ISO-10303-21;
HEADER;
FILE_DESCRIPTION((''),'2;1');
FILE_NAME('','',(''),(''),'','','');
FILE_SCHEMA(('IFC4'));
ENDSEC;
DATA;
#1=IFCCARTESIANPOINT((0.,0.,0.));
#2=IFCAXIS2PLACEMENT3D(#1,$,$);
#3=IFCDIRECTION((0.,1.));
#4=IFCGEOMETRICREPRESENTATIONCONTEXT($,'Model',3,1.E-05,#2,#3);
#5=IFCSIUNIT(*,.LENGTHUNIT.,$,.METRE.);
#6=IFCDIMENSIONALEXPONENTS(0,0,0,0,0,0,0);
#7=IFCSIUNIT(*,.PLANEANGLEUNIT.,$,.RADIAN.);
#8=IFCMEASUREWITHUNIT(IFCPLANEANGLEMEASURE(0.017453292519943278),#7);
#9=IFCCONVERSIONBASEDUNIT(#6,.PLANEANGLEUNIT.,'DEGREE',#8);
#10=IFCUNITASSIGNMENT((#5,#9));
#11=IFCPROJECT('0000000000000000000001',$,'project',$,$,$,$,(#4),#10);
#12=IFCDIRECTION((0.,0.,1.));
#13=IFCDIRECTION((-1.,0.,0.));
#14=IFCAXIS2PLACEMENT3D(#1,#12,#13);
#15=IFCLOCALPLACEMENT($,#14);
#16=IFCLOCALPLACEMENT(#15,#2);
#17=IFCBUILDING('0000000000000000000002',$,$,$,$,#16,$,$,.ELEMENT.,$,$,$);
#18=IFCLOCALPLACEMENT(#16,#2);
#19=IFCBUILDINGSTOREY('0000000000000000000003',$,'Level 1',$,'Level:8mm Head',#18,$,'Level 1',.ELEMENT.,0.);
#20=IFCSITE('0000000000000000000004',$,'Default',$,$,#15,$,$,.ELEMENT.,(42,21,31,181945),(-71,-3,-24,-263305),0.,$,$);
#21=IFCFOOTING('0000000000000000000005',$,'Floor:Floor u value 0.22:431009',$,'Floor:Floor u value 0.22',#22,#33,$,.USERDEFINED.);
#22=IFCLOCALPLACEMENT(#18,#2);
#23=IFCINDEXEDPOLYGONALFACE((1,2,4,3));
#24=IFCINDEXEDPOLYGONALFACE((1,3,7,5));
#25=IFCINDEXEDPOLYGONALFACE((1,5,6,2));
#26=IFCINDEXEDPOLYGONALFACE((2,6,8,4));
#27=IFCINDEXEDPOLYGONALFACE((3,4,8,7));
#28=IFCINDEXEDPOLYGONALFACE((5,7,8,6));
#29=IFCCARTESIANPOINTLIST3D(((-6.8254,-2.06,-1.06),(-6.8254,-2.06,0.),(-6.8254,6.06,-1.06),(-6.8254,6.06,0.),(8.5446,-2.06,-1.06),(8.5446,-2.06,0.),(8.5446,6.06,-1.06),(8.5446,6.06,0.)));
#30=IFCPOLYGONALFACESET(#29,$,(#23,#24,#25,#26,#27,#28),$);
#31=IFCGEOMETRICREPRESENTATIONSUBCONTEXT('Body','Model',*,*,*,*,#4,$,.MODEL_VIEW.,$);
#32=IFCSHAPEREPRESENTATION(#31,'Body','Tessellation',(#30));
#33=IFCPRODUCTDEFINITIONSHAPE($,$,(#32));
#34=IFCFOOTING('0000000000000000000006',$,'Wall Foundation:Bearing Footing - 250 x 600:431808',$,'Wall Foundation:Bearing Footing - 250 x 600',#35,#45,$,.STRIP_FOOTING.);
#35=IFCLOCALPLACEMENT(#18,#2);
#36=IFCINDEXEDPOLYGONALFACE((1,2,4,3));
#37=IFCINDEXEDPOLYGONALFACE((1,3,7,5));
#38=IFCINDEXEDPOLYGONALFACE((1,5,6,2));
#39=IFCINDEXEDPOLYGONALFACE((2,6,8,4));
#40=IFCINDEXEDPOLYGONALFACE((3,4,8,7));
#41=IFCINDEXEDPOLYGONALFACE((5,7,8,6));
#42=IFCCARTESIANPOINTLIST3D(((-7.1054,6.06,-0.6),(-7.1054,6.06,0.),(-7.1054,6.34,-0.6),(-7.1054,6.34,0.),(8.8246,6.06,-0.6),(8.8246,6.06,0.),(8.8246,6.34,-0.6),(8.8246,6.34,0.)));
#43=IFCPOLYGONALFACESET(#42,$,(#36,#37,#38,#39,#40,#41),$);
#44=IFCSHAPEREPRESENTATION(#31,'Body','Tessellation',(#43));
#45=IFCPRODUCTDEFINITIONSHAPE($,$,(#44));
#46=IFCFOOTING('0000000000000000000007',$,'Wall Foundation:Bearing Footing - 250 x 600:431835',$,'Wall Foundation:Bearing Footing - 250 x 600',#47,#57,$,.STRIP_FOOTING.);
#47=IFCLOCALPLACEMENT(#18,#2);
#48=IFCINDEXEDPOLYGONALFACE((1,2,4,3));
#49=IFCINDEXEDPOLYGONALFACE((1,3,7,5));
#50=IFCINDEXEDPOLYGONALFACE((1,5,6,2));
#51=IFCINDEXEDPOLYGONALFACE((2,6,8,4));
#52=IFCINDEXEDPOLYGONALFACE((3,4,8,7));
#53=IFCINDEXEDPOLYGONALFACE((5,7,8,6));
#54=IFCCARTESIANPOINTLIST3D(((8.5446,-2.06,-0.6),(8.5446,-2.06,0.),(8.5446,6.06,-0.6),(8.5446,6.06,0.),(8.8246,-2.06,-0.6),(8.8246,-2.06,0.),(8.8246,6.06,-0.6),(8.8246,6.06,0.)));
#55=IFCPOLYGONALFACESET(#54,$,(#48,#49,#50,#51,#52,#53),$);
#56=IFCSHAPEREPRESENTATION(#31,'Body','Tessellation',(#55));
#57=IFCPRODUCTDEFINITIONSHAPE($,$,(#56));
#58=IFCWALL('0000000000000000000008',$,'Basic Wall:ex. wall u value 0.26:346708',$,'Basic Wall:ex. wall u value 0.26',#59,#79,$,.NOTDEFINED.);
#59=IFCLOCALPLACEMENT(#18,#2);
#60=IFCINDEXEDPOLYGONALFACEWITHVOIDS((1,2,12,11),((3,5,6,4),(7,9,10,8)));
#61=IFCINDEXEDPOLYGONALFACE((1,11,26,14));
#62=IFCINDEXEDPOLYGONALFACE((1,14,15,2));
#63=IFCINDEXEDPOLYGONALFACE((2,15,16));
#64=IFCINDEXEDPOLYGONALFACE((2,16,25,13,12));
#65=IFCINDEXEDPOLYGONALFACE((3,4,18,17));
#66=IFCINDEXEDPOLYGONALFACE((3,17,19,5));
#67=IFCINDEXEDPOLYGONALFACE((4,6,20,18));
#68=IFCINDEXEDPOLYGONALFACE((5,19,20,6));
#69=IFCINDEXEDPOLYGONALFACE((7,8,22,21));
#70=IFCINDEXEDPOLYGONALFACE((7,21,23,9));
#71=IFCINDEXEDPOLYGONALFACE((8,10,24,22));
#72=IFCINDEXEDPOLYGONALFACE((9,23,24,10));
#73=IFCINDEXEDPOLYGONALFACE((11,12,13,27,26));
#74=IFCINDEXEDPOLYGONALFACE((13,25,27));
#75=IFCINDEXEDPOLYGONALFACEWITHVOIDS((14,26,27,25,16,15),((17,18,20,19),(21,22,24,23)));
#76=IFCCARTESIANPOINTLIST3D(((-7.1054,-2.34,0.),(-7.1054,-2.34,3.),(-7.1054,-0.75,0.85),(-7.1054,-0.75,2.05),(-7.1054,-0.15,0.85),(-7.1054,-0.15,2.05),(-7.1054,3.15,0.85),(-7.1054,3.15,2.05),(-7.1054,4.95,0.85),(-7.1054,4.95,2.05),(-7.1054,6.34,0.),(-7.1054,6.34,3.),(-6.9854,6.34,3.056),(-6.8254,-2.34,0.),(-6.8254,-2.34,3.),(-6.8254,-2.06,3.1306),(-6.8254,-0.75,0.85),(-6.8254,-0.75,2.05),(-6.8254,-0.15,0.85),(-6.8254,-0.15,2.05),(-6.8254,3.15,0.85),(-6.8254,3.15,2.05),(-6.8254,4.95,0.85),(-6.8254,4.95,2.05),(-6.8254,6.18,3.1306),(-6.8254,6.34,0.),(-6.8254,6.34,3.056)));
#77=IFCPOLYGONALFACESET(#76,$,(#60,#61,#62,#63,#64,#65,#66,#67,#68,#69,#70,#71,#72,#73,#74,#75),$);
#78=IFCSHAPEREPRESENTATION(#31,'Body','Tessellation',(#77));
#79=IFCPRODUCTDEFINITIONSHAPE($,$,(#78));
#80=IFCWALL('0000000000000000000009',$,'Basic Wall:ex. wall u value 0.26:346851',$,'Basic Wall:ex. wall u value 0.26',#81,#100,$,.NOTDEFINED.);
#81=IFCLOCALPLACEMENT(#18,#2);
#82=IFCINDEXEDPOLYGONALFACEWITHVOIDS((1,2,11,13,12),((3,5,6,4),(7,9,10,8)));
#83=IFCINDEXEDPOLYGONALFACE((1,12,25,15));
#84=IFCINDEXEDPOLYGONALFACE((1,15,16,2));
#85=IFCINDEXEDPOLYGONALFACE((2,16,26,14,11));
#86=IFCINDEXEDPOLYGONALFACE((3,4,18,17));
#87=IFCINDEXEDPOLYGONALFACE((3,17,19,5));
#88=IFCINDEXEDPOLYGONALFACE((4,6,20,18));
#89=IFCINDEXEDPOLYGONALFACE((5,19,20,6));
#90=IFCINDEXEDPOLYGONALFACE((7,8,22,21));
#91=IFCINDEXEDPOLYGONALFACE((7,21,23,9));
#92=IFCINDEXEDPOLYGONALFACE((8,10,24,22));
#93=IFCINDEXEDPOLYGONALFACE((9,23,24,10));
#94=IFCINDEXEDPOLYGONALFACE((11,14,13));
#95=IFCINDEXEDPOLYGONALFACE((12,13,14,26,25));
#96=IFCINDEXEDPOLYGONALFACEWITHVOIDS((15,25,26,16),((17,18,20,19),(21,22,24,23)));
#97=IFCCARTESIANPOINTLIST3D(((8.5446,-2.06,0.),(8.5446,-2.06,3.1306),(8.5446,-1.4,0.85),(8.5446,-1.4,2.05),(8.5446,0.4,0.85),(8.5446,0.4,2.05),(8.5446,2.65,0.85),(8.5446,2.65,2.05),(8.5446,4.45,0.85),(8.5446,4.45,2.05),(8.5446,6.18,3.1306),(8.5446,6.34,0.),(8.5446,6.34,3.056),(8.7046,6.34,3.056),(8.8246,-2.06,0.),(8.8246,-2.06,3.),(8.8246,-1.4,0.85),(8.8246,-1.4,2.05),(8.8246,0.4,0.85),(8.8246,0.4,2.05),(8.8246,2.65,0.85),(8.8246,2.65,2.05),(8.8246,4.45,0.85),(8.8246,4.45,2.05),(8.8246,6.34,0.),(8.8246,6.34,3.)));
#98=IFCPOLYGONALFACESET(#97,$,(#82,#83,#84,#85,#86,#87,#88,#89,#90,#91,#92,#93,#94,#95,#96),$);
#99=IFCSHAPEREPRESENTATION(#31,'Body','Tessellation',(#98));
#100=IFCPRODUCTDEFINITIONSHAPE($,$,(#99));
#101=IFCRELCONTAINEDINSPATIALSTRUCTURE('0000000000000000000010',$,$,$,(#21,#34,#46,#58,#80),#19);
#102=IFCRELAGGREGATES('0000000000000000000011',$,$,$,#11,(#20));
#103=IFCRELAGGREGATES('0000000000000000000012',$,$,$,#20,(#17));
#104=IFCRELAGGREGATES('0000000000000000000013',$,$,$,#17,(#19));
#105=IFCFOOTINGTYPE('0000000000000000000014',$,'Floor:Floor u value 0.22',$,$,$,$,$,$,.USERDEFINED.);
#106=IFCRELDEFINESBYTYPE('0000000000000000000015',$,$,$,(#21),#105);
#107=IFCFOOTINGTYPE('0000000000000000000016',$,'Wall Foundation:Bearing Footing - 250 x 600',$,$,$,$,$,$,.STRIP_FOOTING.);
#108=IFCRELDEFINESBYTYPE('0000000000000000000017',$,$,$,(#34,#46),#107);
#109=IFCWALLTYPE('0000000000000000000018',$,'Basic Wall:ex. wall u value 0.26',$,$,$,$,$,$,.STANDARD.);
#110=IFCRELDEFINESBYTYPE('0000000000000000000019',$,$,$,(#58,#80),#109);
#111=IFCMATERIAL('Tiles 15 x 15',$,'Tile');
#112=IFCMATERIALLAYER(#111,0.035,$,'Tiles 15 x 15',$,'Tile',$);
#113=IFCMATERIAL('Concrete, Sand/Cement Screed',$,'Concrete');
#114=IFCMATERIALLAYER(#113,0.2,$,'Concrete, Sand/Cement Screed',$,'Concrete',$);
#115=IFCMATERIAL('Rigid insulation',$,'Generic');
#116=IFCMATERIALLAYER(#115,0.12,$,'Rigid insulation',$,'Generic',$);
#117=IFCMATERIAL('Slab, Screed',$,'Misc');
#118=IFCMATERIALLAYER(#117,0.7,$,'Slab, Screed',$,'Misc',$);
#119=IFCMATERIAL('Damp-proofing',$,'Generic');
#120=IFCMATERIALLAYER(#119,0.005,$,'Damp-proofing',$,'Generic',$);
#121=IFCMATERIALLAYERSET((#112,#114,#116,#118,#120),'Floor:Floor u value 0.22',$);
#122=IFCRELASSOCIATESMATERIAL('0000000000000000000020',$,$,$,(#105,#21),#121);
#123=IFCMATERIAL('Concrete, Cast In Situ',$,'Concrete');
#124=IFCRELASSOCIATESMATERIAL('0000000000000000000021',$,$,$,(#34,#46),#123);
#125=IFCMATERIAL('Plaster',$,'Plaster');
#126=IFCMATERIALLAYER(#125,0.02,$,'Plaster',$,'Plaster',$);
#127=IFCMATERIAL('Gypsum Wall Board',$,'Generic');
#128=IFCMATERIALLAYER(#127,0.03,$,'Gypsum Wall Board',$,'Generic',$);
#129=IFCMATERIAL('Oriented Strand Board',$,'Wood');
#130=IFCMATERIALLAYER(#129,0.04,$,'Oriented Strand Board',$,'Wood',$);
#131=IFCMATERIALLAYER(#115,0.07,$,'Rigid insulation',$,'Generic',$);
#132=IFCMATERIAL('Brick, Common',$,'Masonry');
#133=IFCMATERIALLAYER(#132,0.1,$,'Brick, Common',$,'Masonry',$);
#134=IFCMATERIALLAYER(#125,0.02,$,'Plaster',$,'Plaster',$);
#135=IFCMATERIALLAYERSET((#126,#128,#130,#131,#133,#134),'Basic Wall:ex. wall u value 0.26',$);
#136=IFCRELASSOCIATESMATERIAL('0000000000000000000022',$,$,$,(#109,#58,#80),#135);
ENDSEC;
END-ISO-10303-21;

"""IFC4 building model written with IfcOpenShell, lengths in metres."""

from ifc_helpers import new_model, entity, si_unit, converted_unit, direction, frame, frame_2d, origin, origin_2d_with_axis, place, context, subcontext, project, spatial, polyline, rectangle, extrude, clip, bounded_halfspace, material, layer, layer_set, layer_usage, type_object, element, save


model = new_model("IFC4")

# Units and contexts
model_context = context("Model", 3, precision=1e-05, world=origin(), true_north=direction((0.0, 1.0)))
body_context = subcontext(model_context, "Body", "Model", "MODEL_VIEW")
ifc_project = project(units=[si_unit("LENGTHUNIT", "METRE"), converted_unit("PLANEANGLEUNIT", "DEGREE", entity("IfcPlaneAngleMeasure", 0.017453292519943278), si_unit("PLANEANGLEUNIT", "RADIAN"), dimensions=[0, 0, 0, 0, 0, 0, 0])], contexts=[model_context])

# Site, building, storey
site_placement = place(None, frame((0.0, 0.0, 0.0), z_axis=(0.0, 0.0, 1.0), x_axis=(-1.0, 0.0, 0.0)))
site = spatial("IfcSite", under=ifc_project, at=site_placement, Name="Default", CompositionType="ELEMENT", RefLatitude=(42, 21, 31, 181945), RefLongitude=(-71, -3, -24, -263305), RefElevation=0.0)
building_placement = place(site_placement, origin())
building = spatial("IfcBuilding", under=site, at=building_placement, CompositionType="ELEMENT")
storey_placement = place(building_placement, origin())
storey = spatial("IfcBuildingStorey", under=building, at=storey_placement, Name="Level 1", ObjectType="Level:8mm Head", LongName="Level 1", CompositionType="ELEMENT", Elevation=0.0)

# Footings
ifc_material_1 = material(Name="Tiles 15 x 15", Category="Tile")
ifc_layer_1 = layer(ifc_material_1, 0.035, Name="Tiles 15 x 15", Category="Tile")
ifc_material_2 = material(Name="Concrete, Sand/Cement Screed", Category="Concrete")
ifc_layer_2 = layer(ifc_material_2, 0.2, Name="Concrete, Sand/Cement Screed", Category="Concrete")
ifc_material_3 = material(Name="Rigid insulation", Category="Generic")
ifc_layer_3 = layer(ifc_material_3, 0.12, Name="Rigid insulation", Category="Generic")
ifc_material_4 = material(Name="Slab, Screed", Category="Misc")
ifc_layer_4 = layer(ifc_material_4, 0.7, Name="Slab, Screed", Category="Misc")
ifc_material_5 = material(Name="Damp-proofing", Category="Generic")
ifc_layer_5 = layer(ifc_material_5, 0.005, Name="Damp-proofing", Category="Generic")
ifc_layer_set_1 = layer_set([ifc_layer_1, ifc_layer_2, ifc_layer_3, ifc_layer_4, ifc_layer_5], Name="Floor:Floor u value 0.22")
ifc_layer_usage_1 = layer_usage(ifc_layer_set_1, "AXIS3", "POSITIVE", 0.0)
footing_type_1 = type_object("IfcFootingType", Name="Floor:Floor u value 0.22", PredefinedType="USERDEFINED", material=ifc_layer_set_1)
footing_1_placement = place(storey_placement, origin())
element("IfcFooting", 1, at=footing_1_placement, inside=storey, type_object=footing_type_1, material=ifc_layer_usage_1, Name="Floor:Floor u value 0.22:431009", ObjectType="Floor:Floor u value 0.22", PredefinedType="USERDEFINED", context=body_context, shape_type="SweptSolid", body=[
    extrude(rectangle(XDim=8.12, YDim=15.37, at=origin_2d_with_axis()), frame((0.8596, 2.0, 0.0), z_axis=(0.0, 0.0, -1.0), x_axis=(0.0, 1.0, 0.0)), (0.0, 0.0, 1.0), 1.06),
])
ifc_material_6 = material(Name="Concrete, Cast In Situ", Category="Concrete")
footing_type_2 = type_object("IfcFootingType", Name="Wall Foundation:Bearing Footing - 250 x 600", PredefinedType="STRIP_FOOTING")
footing_2_placement = place(storey_placement, frame((-7.1054, 6.06, -0.6)))
element("IfcFooting", 2, at=footing_2_placement, inside=storey, type_object=footing_type_2, material=ifc_material_6, Name="Wall Foundation:Bearing Footing - 250 x 600:431808", ObjectType="Wall Foundation:Bearing Footing - 250 x 600", PredefinedType="STRIP_FOOTING", context=body_context, shape_type="SweptSolid", body=[
    extrude(rectangle(XDim=15.93, YDim=0.28, at=frame_2d((0.0, -0.0467), x_axis=(1.0, 0.0))), frame((7.965, 0.0933, 0.0), z_axis=(0.0, 0.0, 1.0), x_axis=(-1.0, 0.0, 0.0)), (0.0, 0.0, 1.0), 0.6),
])
footing_3_placement = place(storey_placement, frame((8.5446, -2.06, -0.6)))
element("IfcFooting", 3, at=footing_3_placement, inside=storey, type_object=footing_type_2, material=ifc_material_6, Name="Wall Foundation:Bearing Footing - 250 x 600:431835", ObjectType="Wall Foundation:Bearing Footing - 250 x 600", PredefinedType="STRIP_FOOTING", context=body_context, shape_type="SweptSolid", body=[
    extrude(rectangle(XDim=8.12, YDim=0.28, at=frame_2d((0.0, 0.0), x_axis=(1.0, 0.0))), frame((0.14, 4.06, 0.0), z_axis=(0.0, 0.0, 1.0), x_axis=(0.0, -1.0, 0.0)), (0.0, 0.0, 1.0), 0.6),
])

# Walls, openings
ifc_material_7 = material(Name="Plaster", Category="Plaster")
ifc_layer_6 = layer(ifc_material_7, 0.02, Name="Plaster", Category="Plaster")
ifc_material_8 = material(Name="Gypsum Wall Board", Category="Generic")
ifc_layer_7 = layer(ifc_material_8, 0.03, Name="Gypsum Wall Board", Category="Generic")
ifc_material_9 = material(Name="Oriented Strand Board", Category="Wood")
ifc_layer_8 = layer(ifc_material_9, 0.04, Name="Oriented Strand Board", Category="Wood")
ifc_layer_9 = layer(ifc_material_3, 0.07, Name="Rigid insulation", Category="Generic")
ifc_material_10 = material(Name="Brick, Common", Category="Masonry")
ifc_layer_10 = layer(ifc_material_10, 0.1, Name="Brick, Common", Category="Masonry")
ifc_layer_11 = layer(ifc_material_7, 0.02, Name="Plaster", Category="Plaster")
ifc_layer_set_2 = layer_set([ifc_layer_6, ifc_layer_7, ifc_layer_8, ifc_layer_9, ifc_layer_10, ifc_layer_11], Name="Basic Wall:ex. wall u value 0.26")
ifc_layer_usage_2 = layer_usage(ifc_layer_set_2, "AXIS2", "POSITIVE", -0.14)
wall_type_1 = type_object("IfcWallType", Name="Basic Wall:ex. wall u value 0.26", PredefinedType="STANDARD", material=ifc_layer_set_2)
wall_1_placement = place(storey_placement, frame((-6.9654, 6.34, 0.0), z_axis=(0.0, 0.0, 1.0), x_axis=(0.0, -1.0, 0.0)))
wall_1 = element("IfcWall", 4, at=wall_1_placement, inside=storey, type_object=wall_type_1, material=ifc_layer_usage_2, Name="Basic Wall:ex. wall u value 0.26:346708", ObjectType="Basic Wall:ex. wall u value 0.26", PredefinedType="NOTDEFINED", context=body_context, shape_type="Clipping", body=[
    clip(clip(clip(extrude(rectangle(XDim=8.68, YDim=0.28, at=frame_2d((4.34, 0.0), x_axis=(-1.0, 0.0))), origin(), (0.0, 0.0, 1.0), 3.1306), bounded_halfspace(frame((0.16, 0.14, 3.1306), z_axis=(-0.422618, 0.0, 0.906308), x_axis=(0.0, -1.0, 0.0)), False, frame((0.16, 0.14, 3.1306)), polyline([(0.0, 0.0), (-0.16, 0.0), (-0.16, -0.16), (0.0, 0.0)]))), bounded_halfspace(frame((0.0, -0.14, 3.0), z_axis=(0.0, -0.422618, 0.906308), x_axis=(1.0, 0.0, 0.0)), False, frame((0.0, -0.14, 3.0)), polyline([(0.0, 0.0), (8.68, 0.0), (8.4, 0.28), (0.28, 0.28), (0.16, 0.28), (0.0, 0.12), (0.0, 0.0)]))), bounded_halfspace(frame((8.68, -0.14, 3.0), z_axis=(0.422618, 0.0, 0.906308), x_axis=(0.0, 1.0, 0.0)), False, frame((8.68, -0.14, 3.0)), polyline([(0.0, 0.0), (0.0, 0.28), (-0.28, 0.28), (0.0, 0.0)]))),
])
opening_1_placement = place(wall_1_placement, frame((3.19, 0.14, 0.85)))
element("IfcOpeningElement", 5, at=opening_1_placement, cuts=wall_1, PredefinedType="OPENING", context=body_context, shape_type="SweptSolid", body=[
    extrude(rectangle(XDim=1.2, YDim=1.8, at=frame_2d((0.6, 0.9), x_axis=(1.0, 0.0))), frame((0.0, 0.0, 0.0), z_axis=(0.0, -1.0, 0.0), x_axis=(0.0, 0.0, 1.0)), (0.0, 0.0, 1.0), 0.28),
])
opening_2_placement = place(wall_1_placement, frame((7.09, 0.14, 0.85)))
element("IfcOpeningElement", 6, at=opening_2_placement, cuts=wall_1, PredefinedType="OPENING", context=body_context, shape_type="SweptSolid", body=[
    extrude(rectangle(XDim=1.2, YDim=0.6, at=frame_2d((0.6, 0.3), x_axis=(1.0, 0.0))), frame((0.0, 0.0, 0.0), z_axis=(0.0, -1.0, 0.0), x_axis=(0.0, 0.0, 1.0)), (0.0, 0.0, 1.0), 0.28),
])
wall_2_placement = place(storey_placement, frame((8.6846, -2.06, 0.0), z_axis=(0.0, 0.0, 1.0), x_axis=(0.0, 1.0, 0.0)))
wall_2 = element("IfcWall", 7, at=wall_2_placement, inside=storey, type_object=wall_type_1, material=ifc_layer_usage_2, Name="Basic Wall:ex. wall u value 0.26:346851", ObjectType="Basic Wall:ex. wall u value 0.26", PredefinedType="NOTDEFINED", context=body_context, shape_type="Clipping", body=[
    clip(clip(extrude(rectangle(XDim=8.4, YDim=0.28, at=frame_2d((4.2, 0.0), x_axis=(-1.0, 0.0))), origin(), (0.0, 0.0, 1.0), 3.1306), bounded_halfspace(frame((8.4, -0.02, 3.056), z_axis=(0.422618, 0.0, 0.906308), x_axis=(0.0, 1.0, 0.0)), False, frame((8.4, -0.02, 3.056)), polyline([(0.0, 0.0), (0.0, 0.16), (-0.16, 0.16), (0.0, 0.0)]))), bounded_halfspace(frame((0.0, -0.14, 3.0), z_axis=(0.0, -0.422618, 0.906308), x_axis=(1.0, 0.0, 0.0)), False, frame((0.0, -0.14, 3.0)), polyline([(0.0, 0.0), (8.4, 0.0), (8.4, 0.12), (8.24, 0.28), (8.12, 0.28), (0.0, 0.28), (0.0, 0.0)]))),
])
opening_3_placement = place(wall_2_placement, frame((6.51, 0.14, 0.85)))
element("IfcOpeningElement", 8, at=opening_3_placement, cuts=wall_2, PredefinedType="OPENING", context=body_context, shape_type="SweptSolid", body=[
    extrude(rectangle(XDim=1.2, YDim=1.8, at=frame_2d((0.6, 0.9), x_axis=(1.0, 0.0))), frame((0.0, 0.0, 0.0), z_axis=(0.0, -1.0, 0.0), x_axis=(0.0, 0.0, 1.0)), (0.0, 0.0, 1.0), 0.28),
])
opening_4_placement = place(wall_2_placement, frame((2.46, 0.14, 0.85)))
element("IfcOpeningElement", 9, at=opening_4_placement, cuts=wall_2, PredefinedType="OPENING", context=body_context, shape_type="SweptSolid", body=[
    extrude(rectangle(XDim=1.2, YDim=1.8, at=frame_2d((0.6, 0.9), x_axis=(1.0, 0.0))), frame((0.0, 0.0, 0.0), z_axis=(0.0, -1.0, 0.0), x_axis=(0.0, 0.0, 1.0)), (0.0, 0.0, 1.0), 0.28),
])

save(model, "model.ifc")
